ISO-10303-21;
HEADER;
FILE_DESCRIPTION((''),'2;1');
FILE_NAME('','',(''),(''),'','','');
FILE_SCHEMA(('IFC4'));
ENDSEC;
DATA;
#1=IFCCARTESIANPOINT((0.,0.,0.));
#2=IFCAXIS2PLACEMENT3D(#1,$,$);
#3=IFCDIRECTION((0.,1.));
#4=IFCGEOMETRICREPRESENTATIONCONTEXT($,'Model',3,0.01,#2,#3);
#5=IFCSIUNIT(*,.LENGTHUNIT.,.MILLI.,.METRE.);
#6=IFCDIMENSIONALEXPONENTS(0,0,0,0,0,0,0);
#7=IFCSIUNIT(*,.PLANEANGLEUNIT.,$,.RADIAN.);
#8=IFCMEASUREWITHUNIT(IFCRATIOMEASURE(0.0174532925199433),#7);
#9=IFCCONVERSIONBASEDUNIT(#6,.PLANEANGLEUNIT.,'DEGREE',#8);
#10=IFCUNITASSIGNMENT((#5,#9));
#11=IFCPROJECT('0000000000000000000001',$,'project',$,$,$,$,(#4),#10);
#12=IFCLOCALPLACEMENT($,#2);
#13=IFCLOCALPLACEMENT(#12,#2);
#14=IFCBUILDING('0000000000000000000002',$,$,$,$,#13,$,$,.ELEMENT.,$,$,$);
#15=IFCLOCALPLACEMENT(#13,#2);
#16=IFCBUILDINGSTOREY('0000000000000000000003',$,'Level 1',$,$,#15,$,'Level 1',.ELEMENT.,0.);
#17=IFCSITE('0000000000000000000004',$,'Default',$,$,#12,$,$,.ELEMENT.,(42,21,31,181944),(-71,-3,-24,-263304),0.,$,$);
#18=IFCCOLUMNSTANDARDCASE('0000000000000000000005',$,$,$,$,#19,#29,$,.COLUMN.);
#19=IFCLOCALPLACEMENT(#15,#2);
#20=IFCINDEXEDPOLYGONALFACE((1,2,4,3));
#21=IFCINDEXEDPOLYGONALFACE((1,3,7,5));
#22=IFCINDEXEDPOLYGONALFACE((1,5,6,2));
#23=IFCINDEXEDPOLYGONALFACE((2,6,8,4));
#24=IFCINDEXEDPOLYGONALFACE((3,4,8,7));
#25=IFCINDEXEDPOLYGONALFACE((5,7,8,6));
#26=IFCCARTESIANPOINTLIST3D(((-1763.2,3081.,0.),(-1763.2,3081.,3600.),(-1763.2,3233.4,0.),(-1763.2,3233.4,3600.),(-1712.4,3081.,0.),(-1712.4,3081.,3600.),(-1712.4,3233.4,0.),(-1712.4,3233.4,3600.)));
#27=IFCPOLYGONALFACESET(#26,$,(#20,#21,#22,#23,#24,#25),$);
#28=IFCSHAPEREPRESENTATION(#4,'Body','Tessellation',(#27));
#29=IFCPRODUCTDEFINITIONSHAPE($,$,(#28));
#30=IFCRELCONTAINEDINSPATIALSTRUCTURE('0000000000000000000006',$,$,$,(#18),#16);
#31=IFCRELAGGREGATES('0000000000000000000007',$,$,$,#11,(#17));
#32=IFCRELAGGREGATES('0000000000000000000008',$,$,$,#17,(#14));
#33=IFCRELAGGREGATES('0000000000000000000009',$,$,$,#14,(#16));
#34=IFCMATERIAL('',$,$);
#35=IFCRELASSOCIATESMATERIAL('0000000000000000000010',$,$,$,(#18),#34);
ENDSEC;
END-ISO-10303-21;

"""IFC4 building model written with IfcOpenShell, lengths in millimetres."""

from ifc_helpers import new_model, entity, si_unit, converted_unit, direction, frame, origin, place, context, project, spatial, rectangle, extrude, material, element, save


model = new_model("IFC4")

# Units and contexts
model_context = context("Model", 3, precision=0.01, world=origin(), true_north=direction((0.0, 1.0)))
ifc_project = project(units=[si_unit("LENGTHUNIT", "METRE", prefix="MILLI"), converted_unit("PLANEANGLEUNIT", "DEGREE", entity("IfcRatioMeasure", 0.0174532925199433), si_unit("PLANEANGLEUNIT", "RADIAN"), dimensions=[0, 0, 0, 0, 0, 0, 0])], contexts=[model_context])

# Site, building, storey
site_placement = place(None, origin())
site = spatial("IfcSite", under=ifc_project, at=site_placement, Name="Default", CompositionType="ELEMENT", RefLatitude=(42, 21, 31, 181944), RefLongitude=(-71, -3, -24, -263304), RefElevation=0.0)
building_placement = place(site_placement, origin())
building = spatial("IfcBuilding", under=site, at=building_placement, CompositionType="ELEMENT")
storey_placement = place(building_placement, origin())
storey = spatial("IfcBuildingStorey", under=building, at=storey_placement, Name="Level 1", LongName="Level 1", CompositionType="ELEMENT", Elevation=0.0)

# Column
ifc_material_1 = material(Name="")
placement_1 = place(storey_placement, frame((-1712.4, 3157.2, 0.0), z_axis=(0.0, 0.0, 1.0), x_axis=(-1.0, 0.0, 0.0)))
column_placement = place(placement_1, frame((25.4, 0.0, 0.0), z_axis=(0.0, 0.0, 1.0), x_axis=(1.0, 0.0, 0.0)))
element("IfcColumnStandardCase", 1, at=column_placement, inside=storey, material=ifc_material_1, PredefinedType="COLUMN", context=model_context, shape_type="SweptSolid", body=[
    extrude(rectangle(XDim=50.8, YDim=152.4), origin(), (0.0, 0.0, 1.0), 3600.0),
])

save(model, "model.ifc")
